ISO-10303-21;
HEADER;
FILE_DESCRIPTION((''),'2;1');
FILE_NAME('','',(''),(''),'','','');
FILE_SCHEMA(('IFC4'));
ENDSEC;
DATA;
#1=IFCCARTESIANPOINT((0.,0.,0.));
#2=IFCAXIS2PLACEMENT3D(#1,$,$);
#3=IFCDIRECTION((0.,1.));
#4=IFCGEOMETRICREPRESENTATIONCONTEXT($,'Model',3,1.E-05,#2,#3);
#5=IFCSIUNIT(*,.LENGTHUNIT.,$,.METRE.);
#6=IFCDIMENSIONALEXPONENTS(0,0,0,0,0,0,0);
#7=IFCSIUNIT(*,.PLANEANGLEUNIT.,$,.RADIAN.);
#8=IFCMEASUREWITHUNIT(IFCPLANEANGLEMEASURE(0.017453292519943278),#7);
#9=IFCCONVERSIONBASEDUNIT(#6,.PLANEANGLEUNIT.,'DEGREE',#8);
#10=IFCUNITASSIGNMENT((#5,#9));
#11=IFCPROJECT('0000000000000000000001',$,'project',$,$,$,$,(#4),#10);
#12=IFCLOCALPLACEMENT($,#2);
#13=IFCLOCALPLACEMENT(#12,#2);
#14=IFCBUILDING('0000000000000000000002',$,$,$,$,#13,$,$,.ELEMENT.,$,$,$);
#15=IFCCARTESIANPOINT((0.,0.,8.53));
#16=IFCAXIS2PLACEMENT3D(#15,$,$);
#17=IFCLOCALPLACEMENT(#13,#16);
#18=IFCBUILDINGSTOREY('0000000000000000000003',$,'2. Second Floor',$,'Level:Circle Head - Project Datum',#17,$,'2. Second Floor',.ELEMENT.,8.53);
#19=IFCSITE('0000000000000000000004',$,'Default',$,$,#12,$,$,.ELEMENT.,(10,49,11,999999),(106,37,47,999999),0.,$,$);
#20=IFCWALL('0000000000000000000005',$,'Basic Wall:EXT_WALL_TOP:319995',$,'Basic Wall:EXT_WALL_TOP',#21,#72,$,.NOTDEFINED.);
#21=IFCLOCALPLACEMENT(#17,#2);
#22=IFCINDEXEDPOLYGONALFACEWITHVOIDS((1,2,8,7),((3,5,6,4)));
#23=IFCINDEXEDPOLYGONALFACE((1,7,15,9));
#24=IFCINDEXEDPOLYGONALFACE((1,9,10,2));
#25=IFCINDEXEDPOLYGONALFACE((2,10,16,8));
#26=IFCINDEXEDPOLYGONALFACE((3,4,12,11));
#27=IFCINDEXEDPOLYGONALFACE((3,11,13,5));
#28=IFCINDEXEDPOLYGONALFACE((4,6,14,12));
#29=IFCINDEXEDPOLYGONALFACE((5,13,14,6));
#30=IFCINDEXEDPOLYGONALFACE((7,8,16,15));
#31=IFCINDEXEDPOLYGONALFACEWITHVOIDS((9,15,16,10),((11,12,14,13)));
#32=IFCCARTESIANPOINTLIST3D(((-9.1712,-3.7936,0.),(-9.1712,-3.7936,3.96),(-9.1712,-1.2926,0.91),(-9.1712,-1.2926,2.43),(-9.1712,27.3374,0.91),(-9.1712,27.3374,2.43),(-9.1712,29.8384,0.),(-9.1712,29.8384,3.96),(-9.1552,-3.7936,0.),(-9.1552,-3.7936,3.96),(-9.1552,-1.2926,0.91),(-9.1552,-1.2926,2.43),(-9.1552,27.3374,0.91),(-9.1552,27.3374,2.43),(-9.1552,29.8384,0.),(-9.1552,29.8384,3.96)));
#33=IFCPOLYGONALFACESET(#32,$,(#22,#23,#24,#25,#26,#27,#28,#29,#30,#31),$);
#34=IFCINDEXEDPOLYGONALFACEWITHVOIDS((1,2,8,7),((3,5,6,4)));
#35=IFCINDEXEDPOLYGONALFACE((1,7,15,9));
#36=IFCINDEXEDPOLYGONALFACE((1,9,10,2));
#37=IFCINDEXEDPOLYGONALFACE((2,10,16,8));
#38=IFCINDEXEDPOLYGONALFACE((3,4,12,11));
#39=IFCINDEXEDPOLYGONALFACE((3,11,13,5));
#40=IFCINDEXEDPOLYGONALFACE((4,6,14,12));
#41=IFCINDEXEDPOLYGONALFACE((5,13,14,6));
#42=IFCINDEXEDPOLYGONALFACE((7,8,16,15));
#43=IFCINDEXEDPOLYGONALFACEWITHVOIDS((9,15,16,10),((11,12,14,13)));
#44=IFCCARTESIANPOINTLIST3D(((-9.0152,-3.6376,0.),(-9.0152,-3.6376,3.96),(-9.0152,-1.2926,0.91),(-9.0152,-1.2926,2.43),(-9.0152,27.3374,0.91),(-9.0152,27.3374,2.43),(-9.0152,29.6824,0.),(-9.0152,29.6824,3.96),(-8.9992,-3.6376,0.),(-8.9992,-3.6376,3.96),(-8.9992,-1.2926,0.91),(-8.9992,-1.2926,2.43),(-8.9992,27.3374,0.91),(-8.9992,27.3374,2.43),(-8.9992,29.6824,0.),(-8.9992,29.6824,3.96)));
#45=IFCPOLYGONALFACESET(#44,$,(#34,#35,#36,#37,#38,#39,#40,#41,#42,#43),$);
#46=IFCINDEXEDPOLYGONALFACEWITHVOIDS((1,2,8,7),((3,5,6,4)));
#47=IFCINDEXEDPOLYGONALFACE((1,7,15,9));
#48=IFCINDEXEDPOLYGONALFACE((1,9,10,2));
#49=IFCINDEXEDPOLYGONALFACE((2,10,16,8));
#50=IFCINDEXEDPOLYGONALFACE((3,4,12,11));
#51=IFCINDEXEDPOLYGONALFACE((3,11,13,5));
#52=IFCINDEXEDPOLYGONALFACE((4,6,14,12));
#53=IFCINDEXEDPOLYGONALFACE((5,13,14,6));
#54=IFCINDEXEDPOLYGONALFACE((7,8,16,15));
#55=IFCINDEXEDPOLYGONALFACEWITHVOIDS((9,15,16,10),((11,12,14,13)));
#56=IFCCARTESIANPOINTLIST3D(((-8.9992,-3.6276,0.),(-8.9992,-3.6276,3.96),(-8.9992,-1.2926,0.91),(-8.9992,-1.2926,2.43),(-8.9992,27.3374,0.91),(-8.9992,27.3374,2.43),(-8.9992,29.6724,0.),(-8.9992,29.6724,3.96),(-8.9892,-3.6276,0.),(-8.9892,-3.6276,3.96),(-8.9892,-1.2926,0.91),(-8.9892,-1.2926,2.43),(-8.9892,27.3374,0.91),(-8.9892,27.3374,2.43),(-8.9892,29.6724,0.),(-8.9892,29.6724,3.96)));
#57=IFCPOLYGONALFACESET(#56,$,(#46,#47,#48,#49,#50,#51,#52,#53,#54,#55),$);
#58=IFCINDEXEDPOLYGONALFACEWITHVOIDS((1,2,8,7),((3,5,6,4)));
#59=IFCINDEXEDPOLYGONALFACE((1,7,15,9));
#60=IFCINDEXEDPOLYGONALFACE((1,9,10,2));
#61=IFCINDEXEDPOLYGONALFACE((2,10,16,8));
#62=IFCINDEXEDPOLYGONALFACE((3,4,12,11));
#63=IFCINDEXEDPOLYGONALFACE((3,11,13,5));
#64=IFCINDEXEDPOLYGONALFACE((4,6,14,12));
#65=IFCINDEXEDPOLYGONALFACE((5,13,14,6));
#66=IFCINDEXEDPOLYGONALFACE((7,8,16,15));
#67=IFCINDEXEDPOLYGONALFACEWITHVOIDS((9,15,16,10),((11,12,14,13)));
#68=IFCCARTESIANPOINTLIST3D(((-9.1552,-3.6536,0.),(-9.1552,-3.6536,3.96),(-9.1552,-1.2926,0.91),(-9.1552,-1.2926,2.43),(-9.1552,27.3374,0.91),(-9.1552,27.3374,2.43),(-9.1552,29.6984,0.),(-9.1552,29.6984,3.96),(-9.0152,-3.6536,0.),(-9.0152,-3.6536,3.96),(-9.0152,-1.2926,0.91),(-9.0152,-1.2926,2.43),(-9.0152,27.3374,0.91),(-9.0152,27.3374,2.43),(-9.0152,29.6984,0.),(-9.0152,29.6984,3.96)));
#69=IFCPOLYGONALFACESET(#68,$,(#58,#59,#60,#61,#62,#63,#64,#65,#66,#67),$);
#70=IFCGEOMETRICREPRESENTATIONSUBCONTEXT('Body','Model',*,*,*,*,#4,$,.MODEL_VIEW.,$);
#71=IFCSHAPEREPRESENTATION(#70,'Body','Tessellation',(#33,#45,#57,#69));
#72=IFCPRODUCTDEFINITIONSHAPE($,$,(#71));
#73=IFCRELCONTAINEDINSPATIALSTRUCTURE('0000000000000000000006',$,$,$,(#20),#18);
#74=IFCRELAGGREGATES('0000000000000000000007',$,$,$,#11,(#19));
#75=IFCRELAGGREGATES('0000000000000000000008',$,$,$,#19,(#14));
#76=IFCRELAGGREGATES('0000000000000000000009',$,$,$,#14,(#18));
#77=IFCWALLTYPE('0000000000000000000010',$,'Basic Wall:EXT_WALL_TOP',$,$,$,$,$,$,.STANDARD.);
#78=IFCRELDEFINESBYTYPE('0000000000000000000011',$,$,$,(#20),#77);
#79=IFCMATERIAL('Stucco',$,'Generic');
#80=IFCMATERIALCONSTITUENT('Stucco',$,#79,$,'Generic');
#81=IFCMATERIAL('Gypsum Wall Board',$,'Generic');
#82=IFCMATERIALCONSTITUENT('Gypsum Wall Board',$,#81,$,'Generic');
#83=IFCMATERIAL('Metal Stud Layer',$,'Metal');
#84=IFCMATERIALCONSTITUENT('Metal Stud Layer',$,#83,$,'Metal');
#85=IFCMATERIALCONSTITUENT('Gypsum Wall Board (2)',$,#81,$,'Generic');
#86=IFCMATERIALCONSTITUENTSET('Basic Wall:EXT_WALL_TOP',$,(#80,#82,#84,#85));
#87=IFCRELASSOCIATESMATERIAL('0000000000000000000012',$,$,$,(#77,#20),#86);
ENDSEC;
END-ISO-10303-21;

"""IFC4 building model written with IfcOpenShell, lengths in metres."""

from ifc_helpers import new_model, entity, si_unit, converted_unit, direction, frame, origin, place, context, subcontext, project, spatial, indexed_curve, outline, extrude, material, constituent, constituent_set, type_object, element, save


model = new_model("IFC4")

# Units and contexts
model_context = context("Model", 3, precision=1e-05, world=origin(), true_north=direction((0.0, 1.0)))
body_context = subcontext(model_context, "Body", "Model", "MODEL_VIEW")
ifc_project = project(units=[si_unit("LENGTHUNIT", "METRE"), converted_unit("PLANEANGLEUNIT", "DEGREE", entity("IfcPlaneAngleMeasure", 0.017453292519943278), si_unit("PLANEANGLEUNIT", "RADIAN"), dimensions=[0, 0, 0, 0, 0, 0, 0])], contexts=[model_context])

# Site, building, storey
site_placement = place(None, origin())
site = spatial("IfcSite", under=ifc_project, at=site_placement, Name="Default", CompositionType="ELEMENT", RefLatitude=(10, 49, 11, 999999), RefLongitude=(106, 37, 47, 999999), RefElevation=0.0)
building_placement = place(site_placement, origin())
building = spatial("IfcBuilding", under=site, at=building_placement, CompositionType="ELEMENT")
storey_placement = place(building_placement, frame((0.0, 0.0, 8.53)))
storey = spatial("IfcBuildingStorey", under=building, at=storey_placement, Name="2. Second Floor", ObjectType="Level:Circle Head - Project Datum", LongName="2. Second Floor", CompositionType="ELEMENT", Elevation=8.53)

# Shared definitions
ifc_material_1 = material(Name="Stucco", Category="Generic")
ifc_material_2 = material(Name="Gypsum Wall Board", Category="Generic")
ifc_material_3 = material(Name="Metal Stud Layer", Category="Metal")

# Wall, opening
ifc_constituent_1 = constituent(ifc_material_1, Name="Stucco", Category="Generic")
ifc_constituent_2 = constituent(ifc_material_2, Name="Gypsum Wall Board", Category="Generic")
ifc_constituent_3 = constituent(ifc_material_3, Name="Metal Stud Layer", Category="Metal")
ifc_constituent_4 = constituent(ifc_material_2, Name="Gypsum Wall Board (2)", Category="Generic")
ifc_constituent_set_1 = constituent_set(constituents=[ifc_constituent_1, ifc_constituent_2, ifc_constituent_3, ifc_constituent_4], Name="Basic Wall:EXT_WALL_TOP")
wall_type_1 = type_object("IfcWallType", Name="Basic Wall:EXT_WALL_TOP", PredefinedType="STANDARD", material=ifc_constituent_set_1)
wall_1_placement = place(storey_placement, frame((-9.0802, 29.6724, 0.0), z_axis=(0.0, 0.0, 1.0), x_axis=(0.0, -1.0, 0.0)))
wall_1 = element("IfcWall", 1, at=wall_1_placement, inside=storey, type_object=wall_type_1, material=ifc_constituent_set_1, Name="Basic Wall:EXT_WALL_TOP:319995", ObjectType="Basic Wall:EXT_WALL_TOP", PredefinedType="NOTDEFINED", context=body_context, shape_type="SweptSolid", body=[
    extrude(outline(indexed_curve([(-1.98, -16.816), (1.98, -16.816), (1.98, 16.816), (-1.98, 16.816), (-1.98, -16.816)], self_intersect=False), holes=[indexed_curve([(0.45, 14.315), (0.45, -14.315), (-1.07, -14.315), (-1.07, 14.315), (0.45, 14.315)], self_intersect=False)]), frame((16.65, -0.091, 1.98), z_axis=(0.0, 1.0, 0.0), x_axis=(0.0, 0.0, 1.0)), (0.0, 0.0, 1.0), 0.016),
    extrude(outline(indexed_curve([(-1.98, -16.66), (1.98, -16.66), (1.98, 16.66), (-1.98, 16.66), (-1.98, -16.66)], self_intersect=False), holes=[indexed_curve([(0.45, 14.315), (0.45, -14.315), (-1.07, -14.315), (-1.07, 14.315), (0.45, 14.315)], self_intersect=False)]), frame((16.65, 0.065, 1.98), z_axis=(0.0, 1.0, 0.0), x_axis=(0.0, 0.0, 1.0)), (0.0, 0.0, 1.0), 0.016),
    extrude(outline(indexed_curve([(-1.98, -16.65), (1.98, -16.65), (1.98, 16.65), (-1.98, 16.65), (-1.98, -16.65)], self_intersect=False), holes=[indexed_curve([(0.45, 14.315), (0.45, -14.315), (-1.07, -14.315), (-1.07, 14.315), (0.45, 14.315)], self_intersect=False)]), frame((16.65, 0.081, 1.98), z_axis=(0.0, 1.0, 0.0), x_axis=(0.0, 0.0, 1.0)), (0.0, 0.0, 1.0), 0.01),
    extrude(outline(indexed_curve([(-1.98, -16.676), (1.98, -16.676), (1.98, 16.676), (-1.98, 16.676), (-1.98, -16.676)], self_intersect=False), holes=[indexed_curve([(0.45, 14.315), (0.45, -14.315), (-1.07, -14.315), (-1.07, 14.315), (0.45, 14.315)], self_intersect=False)]), frame((16.65, -0.075, 1.98), z_axis=(0.0, 1.0, 0.0), x_axis=(0.0, 0.0, 1.0)), (0.0, 0.0, 1.0), 0.14),
])
opening_1_placement = place(wall_1_placement, frame((30.965, 0.091, 0.91)))
element("IfcOpeningElement", 2, at=opening_1_placement, cuts=wall_1, PredefinedType="OPENING", context=body_context, shape_type="SweptSolid", body=[
    extrude(outline(indexed_curve([(1.52, 0.0), (1.52, 28.63), (0.0, 28.63), (0.0, 0.0), (1.52, 0.0)], self_intersect=False)), frame((0.0, 0.0, 0.0), z_axis=(0.0, -1.0, 0.0), x_axis=(0.0, 0.0, 1.0)), (0.0, 0.0, 1.0), 0.182),
])

save(model, "model.ifc")
